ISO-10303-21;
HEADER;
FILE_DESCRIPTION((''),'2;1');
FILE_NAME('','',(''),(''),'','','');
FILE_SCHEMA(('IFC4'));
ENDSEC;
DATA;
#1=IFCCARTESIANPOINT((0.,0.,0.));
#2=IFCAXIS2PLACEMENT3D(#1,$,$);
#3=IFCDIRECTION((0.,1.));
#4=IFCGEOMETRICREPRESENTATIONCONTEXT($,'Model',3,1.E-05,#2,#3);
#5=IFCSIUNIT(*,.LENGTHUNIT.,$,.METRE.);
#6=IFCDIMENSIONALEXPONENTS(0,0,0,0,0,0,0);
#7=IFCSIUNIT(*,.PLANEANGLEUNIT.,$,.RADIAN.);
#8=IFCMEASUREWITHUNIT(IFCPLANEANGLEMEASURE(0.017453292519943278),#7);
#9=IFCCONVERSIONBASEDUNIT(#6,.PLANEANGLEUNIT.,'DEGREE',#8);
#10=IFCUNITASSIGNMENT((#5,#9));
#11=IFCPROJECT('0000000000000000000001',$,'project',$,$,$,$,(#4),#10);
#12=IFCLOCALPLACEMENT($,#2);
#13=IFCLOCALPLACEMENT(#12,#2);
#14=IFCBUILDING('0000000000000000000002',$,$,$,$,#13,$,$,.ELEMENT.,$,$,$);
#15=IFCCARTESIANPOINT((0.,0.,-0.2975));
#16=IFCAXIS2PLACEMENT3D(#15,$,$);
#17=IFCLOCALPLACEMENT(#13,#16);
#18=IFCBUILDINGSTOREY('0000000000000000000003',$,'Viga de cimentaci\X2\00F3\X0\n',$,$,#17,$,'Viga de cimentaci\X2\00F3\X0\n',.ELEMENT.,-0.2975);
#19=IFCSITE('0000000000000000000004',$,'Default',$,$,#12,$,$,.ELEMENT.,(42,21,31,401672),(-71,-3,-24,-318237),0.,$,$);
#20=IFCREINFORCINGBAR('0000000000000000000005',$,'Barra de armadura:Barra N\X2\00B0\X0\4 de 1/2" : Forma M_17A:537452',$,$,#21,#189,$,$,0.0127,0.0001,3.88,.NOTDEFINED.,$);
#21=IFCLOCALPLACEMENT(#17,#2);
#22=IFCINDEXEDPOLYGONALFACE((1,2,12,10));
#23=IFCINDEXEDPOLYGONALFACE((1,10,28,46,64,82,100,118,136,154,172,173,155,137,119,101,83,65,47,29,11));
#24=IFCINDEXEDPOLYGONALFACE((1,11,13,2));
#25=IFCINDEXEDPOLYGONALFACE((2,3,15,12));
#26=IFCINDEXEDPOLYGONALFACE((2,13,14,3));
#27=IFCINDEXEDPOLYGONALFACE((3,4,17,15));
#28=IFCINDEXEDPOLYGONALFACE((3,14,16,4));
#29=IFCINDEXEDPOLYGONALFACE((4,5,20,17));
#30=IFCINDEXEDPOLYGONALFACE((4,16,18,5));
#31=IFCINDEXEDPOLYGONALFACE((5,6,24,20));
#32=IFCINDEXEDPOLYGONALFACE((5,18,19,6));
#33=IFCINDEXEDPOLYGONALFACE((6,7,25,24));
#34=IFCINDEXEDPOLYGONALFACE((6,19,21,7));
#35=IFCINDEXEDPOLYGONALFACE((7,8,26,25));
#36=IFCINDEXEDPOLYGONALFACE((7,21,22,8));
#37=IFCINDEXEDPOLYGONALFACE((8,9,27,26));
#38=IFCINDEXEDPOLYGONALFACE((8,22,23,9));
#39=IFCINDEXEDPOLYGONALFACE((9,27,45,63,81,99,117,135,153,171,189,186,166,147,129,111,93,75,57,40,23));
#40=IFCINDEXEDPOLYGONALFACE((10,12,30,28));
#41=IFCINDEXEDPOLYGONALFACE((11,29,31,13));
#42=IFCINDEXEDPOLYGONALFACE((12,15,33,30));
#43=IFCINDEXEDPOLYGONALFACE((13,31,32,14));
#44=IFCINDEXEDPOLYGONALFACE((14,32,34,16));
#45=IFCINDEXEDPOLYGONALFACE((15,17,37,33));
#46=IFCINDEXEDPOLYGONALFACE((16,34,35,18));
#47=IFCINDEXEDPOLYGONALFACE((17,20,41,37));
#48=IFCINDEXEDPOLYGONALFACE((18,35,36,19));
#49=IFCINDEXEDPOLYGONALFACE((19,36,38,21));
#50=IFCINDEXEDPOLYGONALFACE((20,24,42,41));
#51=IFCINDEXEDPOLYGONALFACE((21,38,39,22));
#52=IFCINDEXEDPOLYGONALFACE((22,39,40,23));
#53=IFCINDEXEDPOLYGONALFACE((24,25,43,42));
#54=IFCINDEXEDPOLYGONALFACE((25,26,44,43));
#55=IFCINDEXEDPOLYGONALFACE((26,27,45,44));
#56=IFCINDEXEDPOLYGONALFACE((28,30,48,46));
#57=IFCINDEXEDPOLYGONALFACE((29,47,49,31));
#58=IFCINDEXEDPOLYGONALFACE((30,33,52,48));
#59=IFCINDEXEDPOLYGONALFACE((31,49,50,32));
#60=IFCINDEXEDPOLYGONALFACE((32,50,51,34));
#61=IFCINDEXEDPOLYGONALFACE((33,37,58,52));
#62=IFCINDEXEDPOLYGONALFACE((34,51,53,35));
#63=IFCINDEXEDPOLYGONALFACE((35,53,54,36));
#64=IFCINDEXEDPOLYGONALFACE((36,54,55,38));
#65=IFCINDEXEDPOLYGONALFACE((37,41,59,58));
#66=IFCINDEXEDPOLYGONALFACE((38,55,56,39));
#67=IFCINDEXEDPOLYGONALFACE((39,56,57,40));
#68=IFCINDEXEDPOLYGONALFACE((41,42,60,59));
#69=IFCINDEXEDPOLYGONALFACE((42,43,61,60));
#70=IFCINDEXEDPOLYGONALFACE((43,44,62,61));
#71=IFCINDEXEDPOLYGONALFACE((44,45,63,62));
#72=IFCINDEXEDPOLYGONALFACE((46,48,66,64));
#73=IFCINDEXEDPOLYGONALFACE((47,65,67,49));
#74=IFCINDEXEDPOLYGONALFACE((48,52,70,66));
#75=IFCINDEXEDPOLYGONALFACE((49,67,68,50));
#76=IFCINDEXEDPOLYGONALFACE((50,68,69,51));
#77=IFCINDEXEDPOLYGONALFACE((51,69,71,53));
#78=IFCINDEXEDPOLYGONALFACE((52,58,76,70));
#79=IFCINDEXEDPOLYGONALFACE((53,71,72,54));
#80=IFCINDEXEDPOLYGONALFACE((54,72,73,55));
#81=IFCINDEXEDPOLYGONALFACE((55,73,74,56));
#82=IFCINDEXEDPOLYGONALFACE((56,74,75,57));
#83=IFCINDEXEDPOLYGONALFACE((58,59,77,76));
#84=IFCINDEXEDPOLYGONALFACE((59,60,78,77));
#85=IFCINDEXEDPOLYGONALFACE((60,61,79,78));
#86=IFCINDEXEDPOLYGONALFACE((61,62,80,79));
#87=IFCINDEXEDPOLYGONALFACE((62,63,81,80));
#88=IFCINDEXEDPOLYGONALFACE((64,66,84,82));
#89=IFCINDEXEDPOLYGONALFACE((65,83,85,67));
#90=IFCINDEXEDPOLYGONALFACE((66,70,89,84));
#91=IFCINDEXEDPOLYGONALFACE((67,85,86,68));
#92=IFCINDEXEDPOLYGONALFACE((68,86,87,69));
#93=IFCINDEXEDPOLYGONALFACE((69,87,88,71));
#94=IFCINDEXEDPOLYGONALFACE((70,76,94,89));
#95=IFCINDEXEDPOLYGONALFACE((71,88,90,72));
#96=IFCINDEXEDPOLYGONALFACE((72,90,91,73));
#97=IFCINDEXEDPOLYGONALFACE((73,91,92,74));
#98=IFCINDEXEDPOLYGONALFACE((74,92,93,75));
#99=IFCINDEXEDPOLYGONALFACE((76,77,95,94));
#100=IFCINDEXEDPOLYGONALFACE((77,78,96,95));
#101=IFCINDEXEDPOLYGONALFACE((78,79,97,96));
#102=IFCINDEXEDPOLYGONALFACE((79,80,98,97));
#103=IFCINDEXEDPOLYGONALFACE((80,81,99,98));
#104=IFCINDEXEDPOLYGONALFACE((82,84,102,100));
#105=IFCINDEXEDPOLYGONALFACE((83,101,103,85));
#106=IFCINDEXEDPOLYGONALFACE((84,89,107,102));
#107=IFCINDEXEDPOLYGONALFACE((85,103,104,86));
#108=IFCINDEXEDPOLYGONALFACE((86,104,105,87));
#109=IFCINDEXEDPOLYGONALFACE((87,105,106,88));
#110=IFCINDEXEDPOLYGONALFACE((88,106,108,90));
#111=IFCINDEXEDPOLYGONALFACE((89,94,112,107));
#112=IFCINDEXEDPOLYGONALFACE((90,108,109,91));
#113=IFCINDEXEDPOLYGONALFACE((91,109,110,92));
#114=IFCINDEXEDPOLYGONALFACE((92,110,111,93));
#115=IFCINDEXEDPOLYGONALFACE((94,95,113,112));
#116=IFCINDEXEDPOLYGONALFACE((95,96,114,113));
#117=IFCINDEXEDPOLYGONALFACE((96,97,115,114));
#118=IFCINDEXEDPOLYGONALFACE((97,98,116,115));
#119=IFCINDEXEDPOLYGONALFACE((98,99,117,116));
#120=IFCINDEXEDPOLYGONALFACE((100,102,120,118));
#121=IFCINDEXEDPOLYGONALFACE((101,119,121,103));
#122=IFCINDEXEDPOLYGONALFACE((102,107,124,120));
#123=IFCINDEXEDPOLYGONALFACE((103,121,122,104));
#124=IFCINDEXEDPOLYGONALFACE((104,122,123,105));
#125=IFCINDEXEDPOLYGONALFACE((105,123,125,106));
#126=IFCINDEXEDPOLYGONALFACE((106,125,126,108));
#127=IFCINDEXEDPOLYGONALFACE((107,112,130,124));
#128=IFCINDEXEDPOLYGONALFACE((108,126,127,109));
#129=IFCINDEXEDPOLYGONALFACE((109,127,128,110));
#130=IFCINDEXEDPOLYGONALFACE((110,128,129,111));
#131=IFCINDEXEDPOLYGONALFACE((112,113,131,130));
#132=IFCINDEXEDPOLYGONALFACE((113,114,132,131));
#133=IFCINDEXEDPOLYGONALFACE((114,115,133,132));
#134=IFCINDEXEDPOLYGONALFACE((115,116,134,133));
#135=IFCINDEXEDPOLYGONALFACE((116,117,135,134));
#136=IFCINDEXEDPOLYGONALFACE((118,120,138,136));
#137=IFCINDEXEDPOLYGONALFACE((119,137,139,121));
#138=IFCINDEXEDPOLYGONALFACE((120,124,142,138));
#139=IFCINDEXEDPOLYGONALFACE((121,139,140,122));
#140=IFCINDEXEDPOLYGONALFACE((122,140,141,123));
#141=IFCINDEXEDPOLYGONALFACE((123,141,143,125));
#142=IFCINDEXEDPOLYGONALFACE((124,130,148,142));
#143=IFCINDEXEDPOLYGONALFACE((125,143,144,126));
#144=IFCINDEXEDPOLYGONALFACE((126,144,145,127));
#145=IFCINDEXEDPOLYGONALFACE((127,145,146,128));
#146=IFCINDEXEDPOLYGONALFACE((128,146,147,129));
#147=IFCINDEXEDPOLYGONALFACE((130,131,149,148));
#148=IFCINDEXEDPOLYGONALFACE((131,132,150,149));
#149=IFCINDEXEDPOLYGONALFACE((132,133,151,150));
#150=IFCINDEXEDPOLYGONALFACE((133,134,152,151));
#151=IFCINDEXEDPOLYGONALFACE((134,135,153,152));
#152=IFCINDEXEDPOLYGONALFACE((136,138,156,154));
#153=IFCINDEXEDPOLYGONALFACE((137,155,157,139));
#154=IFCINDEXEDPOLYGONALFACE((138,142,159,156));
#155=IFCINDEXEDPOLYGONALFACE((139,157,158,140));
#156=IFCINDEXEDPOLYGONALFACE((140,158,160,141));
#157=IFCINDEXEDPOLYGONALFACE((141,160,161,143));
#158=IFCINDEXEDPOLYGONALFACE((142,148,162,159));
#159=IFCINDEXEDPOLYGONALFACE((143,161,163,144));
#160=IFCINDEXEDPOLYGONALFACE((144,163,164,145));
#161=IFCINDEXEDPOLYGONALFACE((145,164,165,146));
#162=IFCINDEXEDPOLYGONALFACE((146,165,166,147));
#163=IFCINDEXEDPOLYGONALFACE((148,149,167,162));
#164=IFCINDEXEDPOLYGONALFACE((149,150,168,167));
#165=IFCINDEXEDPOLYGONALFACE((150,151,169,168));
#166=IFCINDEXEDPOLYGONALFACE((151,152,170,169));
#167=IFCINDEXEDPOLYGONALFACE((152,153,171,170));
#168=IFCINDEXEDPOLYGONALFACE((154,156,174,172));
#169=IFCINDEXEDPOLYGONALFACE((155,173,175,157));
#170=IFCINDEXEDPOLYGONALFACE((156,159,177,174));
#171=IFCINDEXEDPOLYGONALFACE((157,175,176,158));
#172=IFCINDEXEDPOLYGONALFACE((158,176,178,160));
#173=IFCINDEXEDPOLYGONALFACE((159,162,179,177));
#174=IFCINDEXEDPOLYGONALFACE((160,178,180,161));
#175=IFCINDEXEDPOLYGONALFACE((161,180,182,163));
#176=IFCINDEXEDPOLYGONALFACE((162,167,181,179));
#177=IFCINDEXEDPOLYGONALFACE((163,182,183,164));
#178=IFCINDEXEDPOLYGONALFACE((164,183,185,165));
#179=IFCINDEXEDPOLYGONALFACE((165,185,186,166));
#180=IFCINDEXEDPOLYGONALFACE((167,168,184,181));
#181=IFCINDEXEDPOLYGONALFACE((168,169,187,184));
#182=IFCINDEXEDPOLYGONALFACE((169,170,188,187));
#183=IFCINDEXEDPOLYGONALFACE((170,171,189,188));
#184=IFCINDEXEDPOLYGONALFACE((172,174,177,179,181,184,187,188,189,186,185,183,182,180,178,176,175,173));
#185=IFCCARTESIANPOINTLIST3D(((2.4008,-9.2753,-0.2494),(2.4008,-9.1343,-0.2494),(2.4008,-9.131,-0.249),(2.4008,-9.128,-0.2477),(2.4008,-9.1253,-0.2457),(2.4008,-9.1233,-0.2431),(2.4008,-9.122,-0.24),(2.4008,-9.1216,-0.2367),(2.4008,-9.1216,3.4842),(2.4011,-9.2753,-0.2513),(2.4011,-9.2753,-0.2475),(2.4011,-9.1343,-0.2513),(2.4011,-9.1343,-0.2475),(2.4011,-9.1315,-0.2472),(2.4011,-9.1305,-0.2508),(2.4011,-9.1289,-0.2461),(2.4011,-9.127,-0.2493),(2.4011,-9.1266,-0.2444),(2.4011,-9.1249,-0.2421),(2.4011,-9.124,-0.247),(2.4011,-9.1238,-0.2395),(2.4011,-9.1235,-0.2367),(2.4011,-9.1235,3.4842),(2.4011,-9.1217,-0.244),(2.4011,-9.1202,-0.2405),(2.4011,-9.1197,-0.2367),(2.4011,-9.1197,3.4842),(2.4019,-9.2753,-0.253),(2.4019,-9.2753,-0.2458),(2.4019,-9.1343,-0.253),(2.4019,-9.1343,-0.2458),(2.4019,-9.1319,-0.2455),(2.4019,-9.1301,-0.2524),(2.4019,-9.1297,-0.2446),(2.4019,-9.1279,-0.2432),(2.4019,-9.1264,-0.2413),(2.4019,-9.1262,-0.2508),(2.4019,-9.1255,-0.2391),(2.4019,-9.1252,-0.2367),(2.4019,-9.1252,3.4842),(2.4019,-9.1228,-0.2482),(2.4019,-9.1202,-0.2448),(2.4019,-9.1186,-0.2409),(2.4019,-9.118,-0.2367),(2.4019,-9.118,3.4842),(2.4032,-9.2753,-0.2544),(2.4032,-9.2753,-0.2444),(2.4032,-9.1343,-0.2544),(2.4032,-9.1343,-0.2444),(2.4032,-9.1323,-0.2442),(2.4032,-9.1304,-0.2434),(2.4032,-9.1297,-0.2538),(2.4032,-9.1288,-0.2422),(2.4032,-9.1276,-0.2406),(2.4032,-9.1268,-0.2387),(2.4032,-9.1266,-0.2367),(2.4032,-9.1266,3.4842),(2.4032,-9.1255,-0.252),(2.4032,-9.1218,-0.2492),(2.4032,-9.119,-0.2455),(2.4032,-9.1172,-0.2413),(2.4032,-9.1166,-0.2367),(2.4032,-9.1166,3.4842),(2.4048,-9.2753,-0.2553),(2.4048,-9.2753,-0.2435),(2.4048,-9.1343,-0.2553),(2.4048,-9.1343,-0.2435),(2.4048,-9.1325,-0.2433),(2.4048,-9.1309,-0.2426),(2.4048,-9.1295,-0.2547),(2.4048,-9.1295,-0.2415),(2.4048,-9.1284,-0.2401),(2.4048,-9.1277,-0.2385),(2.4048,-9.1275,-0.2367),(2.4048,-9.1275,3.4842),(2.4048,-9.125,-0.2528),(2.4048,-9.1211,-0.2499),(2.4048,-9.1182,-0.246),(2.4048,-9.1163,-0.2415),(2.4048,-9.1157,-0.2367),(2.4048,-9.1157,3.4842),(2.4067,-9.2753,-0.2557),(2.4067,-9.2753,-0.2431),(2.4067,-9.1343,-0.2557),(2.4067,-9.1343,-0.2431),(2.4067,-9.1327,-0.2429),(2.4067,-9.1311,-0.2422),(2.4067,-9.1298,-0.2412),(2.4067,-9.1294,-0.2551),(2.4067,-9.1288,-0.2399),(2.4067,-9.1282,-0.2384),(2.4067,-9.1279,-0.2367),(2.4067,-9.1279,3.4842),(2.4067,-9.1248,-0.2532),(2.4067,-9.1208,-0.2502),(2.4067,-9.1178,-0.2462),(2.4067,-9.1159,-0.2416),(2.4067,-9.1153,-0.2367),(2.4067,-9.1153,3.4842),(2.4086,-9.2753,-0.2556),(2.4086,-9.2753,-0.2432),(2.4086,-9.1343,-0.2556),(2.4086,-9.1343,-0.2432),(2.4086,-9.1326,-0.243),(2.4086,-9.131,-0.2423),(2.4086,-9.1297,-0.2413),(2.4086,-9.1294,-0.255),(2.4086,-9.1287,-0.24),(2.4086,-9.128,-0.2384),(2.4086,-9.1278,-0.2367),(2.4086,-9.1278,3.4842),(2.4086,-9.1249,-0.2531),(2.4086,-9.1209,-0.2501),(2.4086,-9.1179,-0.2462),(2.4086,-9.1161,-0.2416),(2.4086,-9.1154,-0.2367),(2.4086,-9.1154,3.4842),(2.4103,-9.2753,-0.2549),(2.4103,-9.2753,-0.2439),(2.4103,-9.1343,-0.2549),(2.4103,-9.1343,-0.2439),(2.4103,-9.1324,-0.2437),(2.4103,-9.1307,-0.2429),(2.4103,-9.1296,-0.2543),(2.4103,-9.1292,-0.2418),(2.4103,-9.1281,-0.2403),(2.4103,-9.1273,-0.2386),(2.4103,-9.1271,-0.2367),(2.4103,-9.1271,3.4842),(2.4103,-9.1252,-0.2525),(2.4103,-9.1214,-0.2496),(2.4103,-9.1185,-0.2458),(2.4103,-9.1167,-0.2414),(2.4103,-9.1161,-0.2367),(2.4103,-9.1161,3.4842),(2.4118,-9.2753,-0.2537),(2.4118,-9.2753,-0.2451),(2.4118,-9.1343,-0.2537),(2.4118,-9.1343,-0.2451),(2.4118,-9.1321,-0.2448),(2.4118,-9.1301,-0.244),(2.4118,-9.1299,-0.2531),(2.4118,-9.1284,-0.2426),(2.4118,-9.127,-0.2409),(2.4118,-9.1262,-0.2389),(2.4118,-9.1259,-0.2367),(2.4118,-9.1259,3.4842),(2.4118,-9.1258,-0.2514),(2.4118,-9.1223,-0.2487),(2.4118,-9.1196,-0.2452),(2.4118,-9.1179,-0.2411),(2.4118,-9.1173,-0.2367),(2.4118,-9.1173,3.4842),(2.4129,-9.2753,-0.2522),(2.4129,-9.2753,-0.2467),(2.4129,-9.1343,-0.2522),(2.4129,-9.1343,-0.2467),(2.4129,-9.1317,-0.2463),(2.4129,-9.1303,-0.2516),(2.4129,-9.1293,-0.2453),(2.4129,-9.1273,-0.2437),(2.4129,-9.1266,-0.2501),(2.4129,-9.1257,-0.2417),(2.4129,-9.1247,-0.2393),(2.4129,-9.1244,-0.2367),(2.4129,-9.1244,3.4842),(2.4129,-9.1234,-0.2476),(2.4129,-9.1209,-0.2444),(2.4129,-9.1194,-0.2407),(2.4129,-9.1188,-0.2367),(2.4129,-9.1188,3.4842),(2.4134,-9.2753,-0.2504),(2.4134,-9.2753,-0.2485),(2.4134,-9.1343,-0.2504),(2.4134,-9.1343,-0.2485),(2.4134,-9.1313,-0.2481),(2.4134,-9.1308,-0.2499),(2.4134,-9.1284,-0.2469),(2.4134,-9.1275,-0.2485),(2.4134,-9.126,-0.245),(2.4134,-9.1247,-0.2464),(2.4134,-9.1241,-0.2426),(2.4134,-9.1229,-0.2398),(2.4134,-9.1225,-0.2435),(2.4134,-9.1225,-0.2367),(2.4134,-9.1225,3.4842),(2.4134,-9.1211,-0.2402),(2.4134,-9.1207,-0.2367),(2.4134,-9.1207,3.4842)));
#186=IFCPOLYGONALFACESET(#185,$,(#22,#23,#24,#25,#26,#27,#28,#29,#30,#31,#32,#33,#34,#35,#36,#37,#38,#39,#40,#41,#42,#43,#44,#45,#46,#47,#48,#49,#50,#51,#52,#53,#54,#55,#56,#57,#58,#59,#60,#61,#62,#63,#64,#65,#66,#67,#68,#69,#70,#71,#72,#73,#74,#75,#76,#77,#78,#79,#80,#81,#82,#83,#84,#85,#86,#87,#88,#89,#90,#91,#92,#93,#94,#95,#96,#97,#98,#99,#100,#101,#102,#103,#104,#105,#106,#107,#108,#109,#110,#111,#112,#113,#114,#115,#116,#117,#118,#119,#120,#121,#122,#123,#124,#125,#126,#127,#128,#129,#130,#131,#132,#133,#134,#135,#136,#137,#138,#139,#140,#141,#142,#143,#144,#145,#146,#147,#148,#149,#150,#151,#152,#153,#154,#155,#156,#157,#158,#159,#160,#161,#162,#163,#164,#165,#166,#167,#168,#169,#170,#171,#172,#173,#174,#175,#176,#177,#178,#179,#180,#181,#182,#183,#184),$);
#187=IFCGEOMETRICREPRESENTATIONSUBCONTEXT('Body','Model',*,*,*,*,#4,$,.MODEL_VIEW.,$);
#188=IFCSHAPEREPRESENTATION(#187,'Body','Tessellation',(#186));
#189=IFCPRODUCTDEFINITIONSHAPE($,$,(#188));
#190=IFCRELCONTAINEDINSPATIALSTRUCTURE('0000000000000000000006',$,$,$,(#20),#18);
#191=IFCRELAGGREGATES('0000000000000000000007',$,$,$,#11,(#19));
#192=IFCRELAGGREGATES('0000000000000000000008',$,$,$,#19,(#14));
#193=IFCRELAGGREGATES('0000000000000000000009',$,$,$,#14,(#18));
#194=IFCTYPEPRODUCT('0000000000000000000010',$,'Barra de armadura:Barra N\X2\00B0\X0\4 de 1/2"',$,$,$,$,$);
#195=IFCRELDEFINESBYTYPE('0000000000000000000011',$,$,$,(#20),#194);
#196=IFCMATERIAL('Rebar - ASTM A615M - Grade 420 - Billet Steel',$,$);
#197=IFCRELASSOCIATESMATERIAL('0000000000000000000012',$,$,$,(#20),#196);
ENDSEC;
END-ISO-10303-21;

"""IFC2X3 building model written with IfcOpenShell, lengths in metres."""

from ifc_helpers import new_model, entity, si_unit, converted_unit, direction, frame, origin, place, context, subcontext, project, spatial, material, type_object, element, save


model = new_model("IFC2X3")

# Units and contexts
model_context = context("Model", 3, precision=1e-05, world=origin(), true_north=direction((0.0, 1.0)))
body_context = subcontext(model_context, "Body", "Model", "MODEL_VIEW")
ifc_project = project(units=[si_unit("LENGTHUNIT", "METRE"), converted_unit("PLANEANGLEUNIT", "DEGREE", entity("IfcPlaneAngleMeasure", 0.017453292519943278), si_unit("PLANEANGLEUNIT", "RADIAN"), dimensions=[0, 0, 0, 0, 0, 0, 0])], contexts=[model_context])

# Site, building, storey
site_placement = place(None, origin())
site = spatial("IfcSite", under=ifc_project, at=site_placement, Name="Default", CompositionType="ELEMENT", RefLatitude=(42, 21, 31, 401672), RefLongitude=(-71, -3, -24, -318237), RefElevation=0.0)
building_placement = place(site_placement, origin())
building = spatial("IfcBuilding", under=site, at=building_placement, CompositionType="ELEMENT")
storey_placement = place(building_placement, frame((0.0, 0.0, -0.2975)))
storey = spatial("IfcBuildingStorey", under=building, at=storey_placement, Name="Viga de cimentación", LongName="Viga de cimentación", CompositionType="ELEMENT", Elevation=-0.2975)

# Reinforcing bar
ifc_material = material(Name="Rebar - ASTM A615M - Grade 420 - Billet Steel")
type_product_1 = type_object("IfcTypeProduct", Name="Barra de armadura:Barra N°4 de 1/2\"")
reinforcing_bar_1_placement = place(storey_placement, origin())
element("IfcReinforcingBar", 1, at=reinforcing_bar_1_placement, inside=storey, type_object=type_product_1, material=ifc_material, Name="Barra de armadura:Barra N°4 de 1/2\" : Forma M_17A:537452", BarLength=3.88, BarRole="NOTDEFINED", CrossSectionArea=0.0001, NominalDiameter=0.0127, context=body_context, shape_type="AdvancedSweptSolid", body=[
    entity("IfcSweptDiskSolid", entity("IfcCompositeCurve", [entity("IfcCompositeCurveSegment", "CONTINUOUS", True, entity("IfcPolyline", [entity("IfcCartesianPoint", [2.4071, -9.1216, 3.4842]), entity("IfcCartesianPoint", [2.4071, -9.1216, -0.2367])])), entity("IfcCompositeCurveSegment", "CONTINUOUS", True, entity("IfcTrimmedCurve", entity("IfcCircle", entity("IfcAxis2Placement3D", entity("IfcCartesianPoint", [2.4071, -9.1343, -0.2367]), entity("IfcDirection", [-1.0, 0.0, 0.0]), entity("IfcDirection", [0.0, 0.0, -1.0])), 0.0127), [entity("IfcParameterValue", 270.0)], [entity("IfcParameterValue", 360.0)], True, "PARAMETER")), entity("IfcCompositeCurveSegment", "CONTINUOUS", True, entity("IfcPolyline", [entity("IfcCartesianPoint", [2.4071, -9.1343, -0.2494]), entity("IfcCartesianPoint", [2.4071, -9.2753, -0.2494])]))], False), 0.0063, None, 0.0, 92.0),
])

save(model, "model.ifc")
